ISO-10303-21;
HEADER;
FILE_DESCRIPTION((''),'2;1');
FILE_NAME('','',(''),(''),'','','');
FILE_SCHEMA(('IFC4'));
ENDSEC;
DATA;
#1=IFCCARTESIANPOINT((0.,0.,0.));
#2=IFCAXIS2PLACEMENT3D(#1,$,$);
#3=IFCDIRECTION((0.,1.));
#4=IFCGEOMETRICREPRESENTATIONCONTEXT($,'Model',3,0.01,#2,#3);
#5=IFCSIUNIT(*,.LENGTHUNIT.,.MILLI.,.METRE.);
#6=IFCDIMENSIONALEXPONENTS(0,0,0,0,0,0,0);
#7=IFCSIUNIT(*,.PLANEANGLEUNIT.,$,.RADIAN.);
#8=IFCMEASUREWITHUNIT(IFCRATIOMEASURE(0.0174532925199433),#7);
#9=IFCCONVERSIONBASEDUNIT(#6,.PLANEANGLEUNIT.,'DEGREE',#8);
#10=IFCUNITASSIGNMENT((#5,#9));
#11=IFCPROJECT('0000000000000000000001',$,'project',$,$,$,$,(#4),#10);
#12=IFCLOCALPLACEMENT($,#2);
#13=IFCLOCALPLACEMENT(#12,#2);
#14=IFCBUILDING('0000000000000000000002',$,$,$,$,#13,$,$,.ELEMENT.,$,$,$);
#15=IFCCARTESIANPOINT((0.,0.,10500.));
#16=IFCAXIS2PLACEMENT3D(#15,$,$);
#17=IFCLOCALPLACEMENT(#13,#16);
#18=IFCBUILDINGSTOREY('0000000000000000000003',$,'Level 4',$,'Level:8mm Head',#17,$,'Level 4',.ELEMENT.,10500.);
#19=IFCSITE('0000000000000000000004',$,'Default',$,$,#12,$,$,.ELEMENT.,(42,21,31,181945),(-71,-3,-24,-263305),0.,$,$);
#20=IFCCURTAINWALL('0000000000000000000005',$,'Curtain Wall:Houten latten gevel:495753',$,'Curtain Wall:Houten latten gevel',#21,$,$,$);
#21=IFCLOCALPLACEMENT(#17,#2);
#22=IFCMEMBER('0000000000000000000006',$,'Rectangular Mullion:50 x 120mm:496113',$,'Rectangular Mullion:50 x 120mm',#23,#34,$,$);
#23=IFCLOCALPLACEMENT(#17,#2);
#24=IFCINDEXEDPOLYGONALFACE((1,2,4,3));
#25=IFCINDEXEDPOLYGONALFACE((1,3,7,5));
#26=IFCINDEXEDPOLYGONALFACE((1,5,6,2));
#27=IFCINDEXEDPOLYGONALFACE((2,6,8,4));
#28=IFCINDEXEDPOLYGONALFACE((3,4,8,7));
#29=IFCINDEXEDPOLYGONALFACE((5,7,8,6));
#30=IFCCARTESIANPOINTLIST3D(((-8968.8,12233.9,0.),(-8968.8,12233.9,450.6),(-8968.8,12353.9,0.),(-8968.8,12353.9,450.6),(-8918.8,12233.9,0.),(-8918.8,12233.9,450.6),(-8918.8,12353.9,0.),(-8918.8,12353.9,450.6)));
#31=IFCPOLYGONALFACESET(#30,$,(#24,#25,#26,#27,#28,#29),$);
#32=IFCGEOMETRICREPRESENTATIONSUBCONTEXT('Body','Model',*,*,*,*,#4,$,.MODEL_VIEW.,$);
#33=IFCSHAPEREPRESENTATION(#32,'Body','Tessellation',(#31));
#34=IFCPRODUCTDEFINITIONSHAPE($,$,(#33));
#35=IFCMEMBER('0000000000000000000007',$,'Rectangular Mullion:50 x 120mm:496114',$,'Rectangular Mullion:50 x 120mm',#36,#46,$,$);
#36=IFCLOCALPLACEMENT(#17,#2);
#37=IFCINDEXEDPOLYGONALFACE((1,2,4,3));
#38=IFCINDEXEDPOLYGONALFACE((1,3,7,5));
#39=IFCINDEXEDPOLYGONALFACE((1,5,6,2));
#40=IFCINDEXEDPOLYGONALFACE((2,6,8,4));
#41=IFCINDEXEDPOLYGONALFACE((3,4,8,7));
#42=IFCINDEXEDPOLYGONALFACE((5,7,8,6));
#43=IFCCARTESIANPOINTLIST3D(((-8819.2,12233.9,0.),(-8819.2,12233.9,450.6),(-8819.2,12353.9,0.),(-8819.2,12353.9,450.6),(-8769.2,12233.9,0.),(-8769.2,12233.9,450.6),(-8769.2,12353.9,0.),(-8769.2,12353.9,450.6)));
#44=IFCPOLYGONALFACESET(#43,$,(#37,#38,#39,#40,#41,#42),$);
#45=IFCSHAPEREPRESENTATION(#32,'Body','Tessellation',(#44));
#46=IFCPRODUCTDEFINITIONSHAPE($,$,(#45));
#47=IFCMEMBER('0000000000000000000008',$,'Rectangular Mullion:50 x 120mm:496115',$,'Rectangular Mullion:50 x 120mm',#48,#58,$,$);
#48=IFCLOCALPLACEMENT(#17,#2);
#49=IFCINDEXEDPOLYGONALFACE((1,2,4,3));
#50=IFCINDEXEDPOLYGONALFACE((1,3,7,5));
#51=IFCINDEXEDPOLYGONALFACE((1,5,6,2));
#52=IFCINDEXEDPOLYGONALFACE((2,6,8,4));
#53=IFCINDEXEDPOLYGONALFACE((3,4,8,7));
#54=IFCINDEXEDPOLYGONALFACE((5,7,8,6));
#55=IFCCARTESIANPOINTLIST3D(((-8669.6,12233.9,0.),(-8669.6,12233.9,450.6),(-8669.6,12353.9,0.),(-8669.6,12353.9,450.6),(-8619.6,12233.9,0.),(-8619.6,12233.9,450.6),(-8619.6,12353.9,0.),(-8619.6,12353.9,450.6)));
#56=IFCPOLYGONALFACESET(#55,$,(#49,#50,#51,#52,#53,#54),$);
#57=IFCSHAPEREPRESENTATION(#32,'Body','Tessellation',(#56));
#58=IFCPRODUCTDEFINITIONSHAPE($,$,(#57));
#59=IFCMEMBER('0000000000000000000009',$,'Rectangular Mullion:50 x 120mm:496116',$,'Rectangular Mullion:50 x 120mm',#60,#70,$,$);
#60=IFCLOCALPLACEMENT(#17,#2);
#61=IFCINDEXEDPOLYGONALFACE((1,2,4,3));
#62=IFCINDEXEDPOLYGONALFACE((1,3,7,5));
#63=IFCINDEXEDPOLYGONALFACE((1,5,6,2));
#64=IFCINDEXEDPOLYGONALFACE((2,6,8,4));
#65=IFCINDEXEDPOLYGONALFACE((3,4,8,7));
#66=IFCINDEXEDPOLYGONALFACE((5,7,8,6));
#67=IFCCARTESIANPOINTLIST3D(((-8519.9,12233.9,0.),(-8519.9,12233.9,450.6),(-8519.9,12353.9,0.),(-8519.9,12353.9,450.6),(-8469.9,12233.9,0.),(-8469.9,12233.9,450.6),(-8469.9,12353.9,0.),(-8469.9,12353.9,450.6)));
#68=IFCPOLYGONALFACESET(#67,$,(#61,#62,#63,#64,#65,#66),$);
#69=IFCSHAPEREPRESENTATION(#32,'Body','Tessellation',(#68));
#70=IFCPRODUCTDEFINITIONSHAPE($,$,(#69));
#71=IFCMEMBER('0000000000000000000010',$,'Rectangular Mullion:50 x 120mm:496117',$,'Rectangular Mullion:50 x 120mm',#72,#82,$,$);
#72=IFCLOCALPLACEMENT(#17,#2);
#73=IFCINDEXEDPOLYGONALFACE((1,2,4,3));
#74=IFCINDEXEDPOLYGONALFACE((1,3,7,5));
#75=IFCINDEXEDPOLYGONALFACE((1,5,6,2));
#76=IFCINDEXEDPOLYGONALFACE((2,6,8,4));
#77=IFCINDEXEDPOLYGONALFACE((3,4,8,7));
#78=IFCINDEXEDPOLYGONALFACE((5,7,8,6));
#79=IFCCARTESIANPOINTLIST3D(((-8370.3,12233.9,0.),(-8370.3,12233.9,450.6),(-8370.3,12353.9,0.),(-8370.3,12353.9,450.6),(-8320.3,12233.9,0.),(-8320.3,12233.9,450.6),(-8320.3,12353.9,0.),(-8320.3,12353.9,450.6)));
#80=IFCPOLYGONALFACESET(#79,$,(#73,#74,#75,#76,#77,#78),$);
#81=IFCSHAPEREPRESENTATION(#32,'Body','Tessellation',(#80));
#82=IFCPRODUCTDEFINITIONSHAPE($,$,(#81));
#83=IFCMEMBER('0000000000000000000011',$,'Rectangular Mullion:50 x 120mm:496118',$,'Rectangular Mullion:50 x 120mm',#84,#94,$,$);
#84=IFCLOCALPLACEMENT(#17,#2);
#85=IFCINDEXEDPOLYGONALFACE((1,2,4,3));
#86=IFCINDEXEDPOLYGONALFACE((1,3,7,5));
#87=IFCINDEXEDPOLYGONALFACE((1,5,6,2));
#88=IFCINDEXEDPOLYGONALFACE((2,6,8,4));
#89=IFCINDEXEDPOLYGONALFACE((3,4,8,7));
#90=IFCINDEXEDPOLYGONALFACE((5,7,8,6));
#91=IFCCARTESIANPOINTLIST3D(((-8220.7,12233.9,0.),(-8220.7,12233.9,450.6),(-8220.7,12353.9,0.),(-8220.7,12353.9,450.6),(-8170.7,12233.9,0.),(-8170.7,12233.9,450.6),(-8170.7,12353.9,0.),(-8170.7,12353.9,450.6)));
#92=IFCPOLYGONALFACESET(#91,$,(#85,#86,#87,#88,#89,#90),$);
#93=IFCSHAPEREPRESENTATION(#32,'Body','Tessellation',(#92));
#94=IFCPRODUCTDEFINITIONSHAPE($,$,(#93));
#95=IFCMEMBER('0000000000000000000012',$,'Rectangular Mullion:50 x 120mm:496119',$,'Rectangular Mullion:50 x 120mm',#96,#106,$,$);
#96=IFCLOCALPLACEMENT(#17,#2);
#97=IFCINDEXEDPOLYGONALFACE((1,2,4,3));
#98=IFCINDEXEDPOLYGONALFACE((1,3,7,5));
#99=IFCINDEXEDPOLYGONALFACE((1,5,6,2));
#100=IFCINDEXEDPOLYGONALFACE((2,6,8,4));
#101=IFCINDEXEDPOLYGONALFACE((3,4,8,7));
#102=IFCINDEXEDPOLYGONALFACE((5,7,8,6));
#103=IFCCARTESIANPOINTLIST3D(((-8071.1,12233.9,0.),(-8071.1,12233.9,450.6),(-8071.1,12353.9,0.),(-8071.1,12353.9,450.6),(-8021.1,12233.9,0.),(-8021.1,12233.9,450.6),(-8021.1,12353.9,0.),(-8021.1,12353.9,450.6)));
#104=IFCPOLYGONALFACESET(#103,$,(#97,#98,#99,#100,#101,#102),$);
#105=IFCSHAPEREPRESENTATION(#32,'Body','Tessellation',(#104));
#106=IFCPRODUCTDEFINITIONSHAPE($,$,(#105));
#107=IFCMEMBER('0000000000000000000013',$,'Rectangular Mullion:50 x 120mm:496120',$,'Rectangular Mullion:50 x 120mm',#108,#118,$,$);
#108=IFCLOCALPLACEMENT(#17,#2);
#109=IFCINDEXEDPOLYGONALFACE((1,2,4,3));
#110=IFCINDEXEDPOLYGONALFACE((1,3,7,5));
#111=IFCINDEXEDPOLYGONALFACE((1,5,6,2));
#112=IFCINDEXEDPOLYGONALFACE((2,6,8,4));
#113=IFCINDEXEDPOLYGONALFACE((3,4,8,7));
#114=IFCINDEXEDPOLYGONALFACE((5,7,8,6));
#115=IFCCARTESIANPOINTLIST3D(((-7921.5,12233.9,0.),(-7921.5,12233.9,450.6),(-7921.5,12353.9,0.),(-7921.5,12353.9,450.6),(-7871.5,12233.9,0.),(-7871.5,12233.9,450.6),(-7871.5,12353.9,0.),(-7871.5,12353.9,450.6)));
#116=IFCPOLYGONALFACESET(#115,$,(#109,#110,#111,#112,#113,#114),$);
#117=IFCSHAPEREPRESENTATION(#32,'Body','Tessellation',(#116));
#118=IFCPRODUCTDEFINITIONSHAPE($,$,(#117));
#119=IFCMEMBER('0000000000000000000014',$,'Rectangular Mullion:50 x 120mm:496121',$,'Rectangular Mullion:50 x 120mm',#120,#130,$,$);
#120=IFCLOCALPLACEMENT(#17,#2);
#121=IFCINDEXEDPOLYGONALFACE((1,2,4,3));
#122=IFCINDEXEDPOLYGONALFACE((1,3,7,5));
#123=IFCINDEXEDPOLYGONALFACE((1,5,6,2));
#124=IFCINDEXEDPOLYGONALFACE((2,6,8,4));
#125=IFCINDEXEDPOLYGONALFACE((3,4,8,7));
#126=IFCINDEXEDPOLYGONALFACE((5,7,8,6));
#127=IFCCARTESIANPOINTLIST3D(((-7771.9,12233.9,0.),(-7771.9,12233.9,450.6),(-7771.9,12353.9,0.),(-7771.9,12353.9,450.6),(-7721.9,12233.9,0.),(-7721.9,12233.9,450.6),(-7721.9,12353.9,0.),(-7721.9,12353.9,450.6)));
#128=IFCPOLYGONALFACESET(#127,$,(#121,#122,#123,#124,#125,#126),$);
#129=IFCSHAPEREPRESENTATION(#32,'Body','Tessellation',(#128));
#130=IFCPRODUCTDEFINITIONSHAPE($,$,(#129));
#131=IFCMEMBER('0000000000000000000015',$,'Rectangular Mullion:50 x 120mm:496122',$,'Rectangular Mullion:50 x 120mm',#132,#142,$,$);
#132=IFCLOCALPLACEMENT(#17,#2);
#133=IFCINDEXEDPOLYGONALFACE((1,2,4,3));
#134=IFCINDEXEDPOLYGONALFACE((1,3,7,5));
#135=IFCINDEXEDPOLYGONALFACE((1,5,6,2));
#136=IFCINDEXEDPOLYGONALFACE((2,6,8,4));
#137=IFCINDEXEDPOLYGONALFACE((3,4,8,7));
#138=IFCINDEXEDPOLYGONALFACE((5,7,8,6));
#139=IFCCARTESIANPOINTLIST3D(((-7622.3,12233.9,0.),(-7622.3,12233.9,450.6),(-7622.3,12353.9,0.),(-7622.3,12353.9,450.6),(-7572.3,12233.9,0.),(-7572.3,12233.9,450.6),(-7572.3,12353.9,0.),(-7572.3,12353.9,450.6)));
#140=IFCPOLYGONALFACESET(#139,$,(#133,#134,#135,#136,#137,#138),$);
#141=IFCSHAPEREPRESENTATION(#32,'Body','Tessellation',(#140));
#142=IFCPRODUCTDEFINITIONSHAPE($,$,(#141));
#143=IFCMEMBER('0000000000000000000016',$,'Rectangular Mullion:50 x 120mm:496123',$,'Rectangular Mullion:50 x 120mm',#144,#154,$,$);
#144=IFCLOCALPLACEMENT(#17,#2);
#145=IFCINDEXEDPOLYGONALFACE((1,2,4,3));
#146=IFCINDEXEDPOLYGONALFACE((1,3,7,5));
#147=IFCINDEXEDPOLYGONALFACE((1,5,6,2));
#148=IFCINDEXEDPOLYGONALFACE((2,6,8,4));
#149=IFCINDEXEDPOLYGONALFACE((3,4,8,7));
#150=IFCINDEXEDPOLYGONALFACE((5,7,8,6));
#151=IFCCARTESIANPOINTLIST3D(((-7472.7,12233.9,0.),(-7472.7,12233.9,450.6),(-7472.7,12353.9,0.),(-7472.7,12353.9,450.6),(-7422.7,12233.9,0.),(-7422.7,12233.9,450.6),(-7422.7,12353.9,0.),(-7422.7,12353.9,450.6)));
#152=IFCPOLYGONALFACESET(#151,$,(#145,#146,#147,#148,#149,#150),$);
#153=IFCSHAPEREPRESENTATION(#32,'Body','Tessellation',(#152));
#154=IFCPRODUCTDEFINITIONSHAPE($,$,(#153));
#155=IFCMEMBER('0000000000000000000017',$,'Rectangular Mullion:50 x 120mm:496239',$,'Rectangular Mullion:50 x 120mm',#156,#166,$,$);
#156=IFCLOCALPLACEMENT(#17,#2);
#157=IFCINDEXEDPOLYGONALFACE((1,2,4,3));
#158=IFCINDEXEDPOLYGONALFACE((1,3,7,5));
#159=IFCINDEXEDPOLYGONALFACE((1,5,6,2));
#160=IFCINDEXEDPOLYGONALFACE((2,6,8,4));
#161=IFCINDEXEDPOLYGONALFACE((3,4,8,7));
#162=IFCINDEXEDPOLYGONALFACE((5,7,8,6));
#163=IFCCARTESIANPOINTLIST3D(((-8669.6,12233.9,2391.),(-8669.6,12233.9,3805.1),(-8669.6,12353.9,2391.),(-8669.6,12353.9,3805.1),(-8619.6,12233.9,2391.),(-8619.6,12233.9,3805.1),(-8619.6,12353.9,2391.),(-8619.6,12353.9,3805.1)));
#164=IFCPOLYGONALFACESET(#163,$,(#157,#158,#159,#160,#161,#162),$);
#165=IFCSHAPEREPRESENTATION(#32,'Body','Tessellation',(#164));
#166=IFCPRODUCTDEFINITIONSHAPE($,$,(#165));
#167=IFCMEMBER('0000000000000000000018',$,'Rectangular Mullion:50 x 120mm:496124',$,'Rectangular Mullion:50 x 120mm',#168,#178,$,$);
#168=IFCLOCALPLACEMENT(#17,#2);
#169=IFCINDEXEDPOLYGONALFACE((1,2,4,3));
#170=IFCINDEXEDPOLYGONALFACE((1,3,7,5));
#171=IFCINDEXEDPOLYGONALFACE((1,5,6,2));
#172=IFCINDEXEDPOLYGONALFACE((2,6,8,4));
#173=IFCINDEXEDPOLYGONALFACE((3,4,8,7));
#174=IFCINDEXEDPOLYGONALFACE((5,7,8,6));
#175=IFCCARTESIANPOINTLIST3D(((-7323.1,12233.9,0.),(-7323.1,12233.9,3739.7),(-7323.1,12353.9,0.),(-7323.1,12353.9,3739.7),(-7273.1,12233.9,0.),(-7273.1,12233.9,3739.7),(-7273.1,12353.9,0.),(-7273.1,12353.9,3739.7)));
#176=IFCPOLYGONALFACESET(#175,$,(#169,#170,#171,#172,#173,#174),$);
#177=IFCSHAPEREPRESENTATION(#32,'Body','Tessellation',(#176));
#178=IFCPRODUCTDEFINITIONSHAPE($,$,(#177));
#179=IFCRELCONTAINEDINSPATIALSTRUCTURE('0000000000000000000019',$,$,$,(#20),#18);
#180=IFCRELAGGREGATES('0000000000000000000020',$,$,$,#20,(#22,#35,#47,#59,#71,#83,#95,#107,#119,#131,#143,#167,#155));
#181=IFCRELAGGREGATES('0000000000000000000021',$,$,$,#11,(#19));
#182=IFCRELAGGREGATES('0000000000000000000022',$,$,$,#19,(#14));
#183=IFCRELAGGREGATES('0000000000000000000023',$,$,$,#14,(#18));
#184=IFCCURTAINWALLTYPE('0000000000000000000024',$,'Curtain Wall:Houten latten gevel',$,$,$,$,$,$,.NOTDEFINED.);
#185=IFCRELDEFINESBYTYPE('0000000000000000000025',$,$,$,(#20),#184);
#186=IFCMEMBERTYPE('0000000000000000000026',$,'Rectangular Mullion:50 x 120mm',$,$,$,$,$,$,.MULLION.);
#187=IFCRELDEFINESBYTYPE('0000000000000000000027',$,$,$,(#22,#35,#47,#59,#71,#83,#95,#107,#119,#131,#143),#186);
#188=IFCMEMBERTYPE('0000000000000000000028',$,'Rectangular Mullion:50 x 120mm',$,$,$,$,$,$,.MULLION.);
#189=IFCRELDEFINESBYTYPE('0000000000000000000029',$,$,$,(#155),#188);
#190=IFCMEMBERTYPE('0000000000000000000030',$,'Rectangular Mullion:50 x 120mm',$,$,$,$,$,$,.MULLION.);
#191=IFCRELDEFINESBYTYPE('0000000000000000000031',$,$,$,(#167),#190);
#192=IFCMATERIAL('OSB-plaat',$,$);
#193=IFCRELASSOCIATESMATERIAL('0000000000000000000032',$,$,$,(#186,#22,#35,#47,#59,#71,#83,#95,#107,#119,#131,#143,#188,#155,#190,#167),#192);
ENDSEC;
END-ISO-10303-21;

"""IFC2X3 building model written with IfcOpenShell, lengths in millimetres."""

from ifc_helpers import new_model, entity, si_unit, converted_unit, direction, frame, origin, origin_2d_with_axis, place, context, subcontext, project, spatial, rectangle, extrude, source, transform, mapped, material, type_object, type_shapes, element, aggregate, save


model = new_model("IFC2X3")

# Units and contexts
model_context = context("Model", 3, precision=0.01, world=origin(), true_north=direction((0.0, 1.0)))
body_context = subcontext(model_context, "Body", "Model", "MODEL_VIEW")
ifc_project = project(units=[si_unit("LENGTHUNIT", "METRE", prefix="MILLI"), converted_unit("PLANEANGLEUNIT", "DEGREE", entity("IfcRatioMeasure", 0.0174532925199433), si_unit("PLANEANGLEUNIT", "RADIAN"), dimensions=[0, 0, 0, 0, 0, 0, 0])], contexts=[model_context])

# Site, building, storey
site_placement = place(None, frame((0.0, 0.0, 0.0)))
site = spatial("IfcSite", under=ifc_project, at=site_placement, Name="Default", CompositionType="ELEMENT", RefLatitude=(42, 21, 31, 181945), RefLongitude=(-71, -3, -24, -263305), RefElevation=0.0)
building_placement = place(site_placement, origin())
building = spatial("IfcBuilding", under=site, at=building_placement, CompositionType="ELEMENT")
storey_placement = place(building_placement, frame((0.0, 0.0, 10500.0)))
storey = spatial("IfcBuildingStorey", under=building, at=storey_placement, Name="Level 4", ObjectType="Level:8mm Head", LongName="Level 4", CompositionType="ELEMENT", Elevation=10500.0)

# Curtain wall, members
curtain_wall_type = type_object("IfcCurtainWallType", Name="Curtain Wall:Houten latten gevel", PredefinedType="NOTDEFINED")
curtain_wall_placement = place(storey_placement, frame((0.0, 0.0, -10500.0)))
curtain_wall = element("IfcCurtainWall", 1, at=curtain_wall_placement, inside=storey, type_object=curtain_wall_type, Name="Curtain Wall:Houten latten gevel:495753", ObjectType="Curtain Wall:Houten latten gevel")
ifc_material = material(Name="OSB-plaat")
member_type_1 = type_object("IfcMemberType", Name="Rectangular Mullion:50 x 120mm", PredefinedType="MULLION", material=ifc_material)
shared_shape_1 = source(origin(), body_context, "Body", "SweptSolid", [
    extrude(rectangle(XDim=120.0, YDim=50.0, at=origin_2d_with_axis()), frame((0.0, 0.0, -450.6), z_axis=(0.0, 0.0, 1.0), x_axis=(0.0, -1.0, 0.0)), (0.0, 0.0, 1.0), 450.6),
])
type_shapes(member_type_1, [shared_shape_1])
placement = place(building_placement, frame((0.0, 0.0, 7500.0)))
member_1_placement = place(placement, frame((-8943.8, 12293.9, 3000.0), z_axis=(0.0, 0.0, -1.0), x_axis=(1.0, 0.0, 0.0)))
member_1 = element("IfcMember", 2, at=member_1_placement, type_object=member_type_1, material=ifc_material, Name="Rectangular Mullion:50 x 120mm:496113", ObjectType="Rectangular Mullion:50 x 120mm", context=body_context, shape_type="MappedRepresentation", body=[
    mapped(shared_shape_1, transform((0.0, 0.0, 0.0), scale=1.0)),
])
member_2_placement = place(placement, frame((-8794.2, 12293.9, 3000.0), z_axis=(0.0, 0.0, -1.0), x_axis=(1.0, 0.0, 0.0)))
member_2 = element("IfcMember", 3, at=member_2_placement, type_object=member_type_1, material=ifc_material, Name="Rectangular Mullion:50 x 120mm:496114", ObjectType="Rectangular Mullion:50 x 120mm", context=body_context, shape_type="MappedRepresentation", body=[
    mapped(shared_shape_1, transform((0.0, 0.0, 0.0), scale=1.0)),
])
member_3_placement = place(placement, frame((-8644.6, 12293.9, 3000.0), z_axis=(0.0, 0.0, -1.0), x_axis=(1.0, 0.0, 0.0)))
member_3 = element("IfcMember", 4, at=member_3_placement, type_object=member_type_1, material=ifc_material, Name="Rectangular Mullion:50 x 120mm:496115", ObjectType="Rectangular Mullion:50 x 120mm", context=body_context, shape_type="MappedRepresentation", body=[
    mapped(shared_shape_1, transform((0.0, 0.0, 0.0), scale=1.0)),
])
member_4_placement = place(placement, frame((-8494.9, 12293.9, 3000.0), z_axis=(0.0, 0.0, -1.0), x_axis=(1.0, 0.0, 0.0)))
member_4 = element("IfcMember", 5, at=member_4_placement, type_object=member_type_1, material=ifc_material, Name="Rectangular Mullion:50 x 120mm:496116", ObjectType="Rectangular Mullion:50 x 120mm", context=body_context, shape_type="MappedRepresentation", body=[
    mapped(shared_shape_1, transform((0.0, 0.0, 0.0), scale=1.0)),
])
member_5_placement = place(placement, frame((-8345.3, 12293.9, 3000.0), z_axis=(0.0, 0.0, -1.0), x_axis=(1.0, 0.0, 0.0)))
member_5 = element("IfcMember", 6, at=member_5_placement, type_object=member_type_1, material=ifc_material, Name="Rectangular Mullion:50 x 120mm:496117", ObjectType="Rectangular Mullion:50 x 120mm", context=body_context, shape_type="MappedRepresentation", body=[
    mapped(shared_shape_1, transform((0.0, 0.0, 0.0), scale=1.0)),
])
member_6_placement = place(placement, frame((-8195.7, 12293.9, 3000.0), z_axis=(0.0, 0.0, -1.0), x_axis=(1.0, 0.0, 0.0)))
member_6 = element("IfcMember", 7, at=member_6_placement, type_object=member_type_1, material=ifc_material, Name="Rectangular Mullion:50 x 120mm:496118", ObjectType="Rectangular Mullion:50 x 120mm", context=body_context, shape_type="MappedRepresentation", body=[
    mapped(shared_shape_1, transform((0.0, 0.0, 0.0), scale=1.0)),
])
member_7_placement = place(placement, frame((-8046.1, 12293.9, 3000.0), z_axis=(0.0, 0.0, -1.0), x_axis=(1.0, 0.0, 0.0)))
member_7 = element("IfcMember", 8, at=member_7_placement, type_object=member_type_1, material=ifc_material, Name="Rectangular Mullion:50 x 120mm:496119", ObjectType="Rectangular Mullion:50 x 120mm", context=body_context, shape_type="MappedRepresentation", body=[
    mapped(shared_shape_1, transform((0.0, 0.0, 0.0), scale=1.0)),
])
member_8_placement = place(placement, frame((-7896.5, 12293.9, 3000.0), z_axis=(0.0, 0.0, -1.0), x_axis=(1.0, 0.0, 0.0)))
member_8 = element("IfcMember", 9, at=member_8_placement, type_object=member_type_1, material=ifc_material, Name="Rectangular Mullion:50 x 120mm:496120", ObjectType="Rectangular Mullion:50 x 120mm", context=body_context, shape_type="MappedRepresentation", body=[
    mapped(shared_shape_1, transform((0.0, 0.0, 0.0), scale=1.0)),
])
member_9_placement = place(placement, frame((-7746.9, 12293.9, 3000.0), z_axis=(0.0, 0.0, -1.0), x_axis=(1.0, 0.0, 0.0)))
member_9 = element("IfcMember", 10, at=member_9_placement, type_object=member_type_1, material=ifc_material, Name="Rectangular Mullion:50 x 120mm:496121", ObjectType="Rectangular Mullion:50 x 120mm", context=body_context, shape_type="MappedRepresentation", body=[
    mapped(shared_shape_1, transform((0.0, 0.0, 0.0), scale=1.0)),
])
member_10_placement = place(placement, frame((-7597.3, 12293.9, 3000.0), z_axis=(0.0, 0.0, -1.0), x_axis=(1.0, 0.0, 0.0)))
member_10 = element("IfcMember", 11, at=member_10_placement, type_object=member_type_1, material=ifc_material, Name="Rectangular Mullion:50 x 120mm:496122", ObjectType="Rectangular Mullion:50 x 120mm", context=body_context, shape_type="MappedRepresentation", body=[
    mapped(shared_shape_1, transform((0.0, 0.0, 0.0), scale=1.0)),
])
member_11_placement = place(placement, frame((-7447.7, 12293.9, 3000.0), z_axis=(0.0, 0.0, -1.0), x_axis=(1.0, 0.0, 0.0)))
member_11 = element("IfcMember", 12, at=member_11_placement, type_object=member_type_1, material=ifc_material, Name="Rectangular Mullion:50 x 120mm:496123", ObjectType="Rectangular Mullion:50 x 120mm", context=body_context, shape_type="MappedRepresentation", body=[
    mapped(shared_shape_1, transform((0.0, 0.0, 0.0), scale=1.0)),
])
member_type_2 = type_object("IfcMemberType", Name="Rectangular Mullion:50 x 120mm", PredefinedType="MULLION", material=ifc_material)
shared_shape_2 = source(origin(), body_context, "Body", "SweptSolid", [
    extrude(rectangle(XDim=120.0, YDim=50.0, at=origin_2d_with_axis()), frame((0.0, 0.0, -1414.1), z_axis=(0.0, 0.0, 1.0), x_axis=(0.0, -1.0, 0.0)), (0.0, 0.0, 1.0), 1414.1),
])
type_shapes(member_type_2, [shared_shape_2])
member_12_placement = place(placement, frame((-8644.6, 12293.9, 5391.0), z_axis=(0.0, 0.0, -1.0), x_axis=(1.0, 0.0, 0.0)))
member_12 = element("IfcMember", 13, at=member_12_placement, type_object=member_type_2, material=ifc_material, Name="Rectangular Mullion:50 x 120mm:496239", ObjectType="Rectangular Mullion:50 x 120mm", context=body_context, shape_type="MappedRepresentation", body=[
    mapped(shared_shape_2, transform((0.0, 0.0, 0.0), scale=1.0)),
])
member_type_3 = type_object("IfcMemberType", Name="Rectangular Mullion:50 x 120mm", PredefinedType="MULLION", material=ifc_material)
shared_shape_3 = source(origin(), body_context, "Body", "SweptSolid", [
    extrude(rectangle(XDim=120.0, YDim=50.0, at=origin_2d_with_axis()), frame((0.0, 0.0, -3739.7), z_axis=(0.0, 0.0, 1.0), x_axis=(0.0, -1.0, 0.0)), (0.0, 0.0, 1.0), 3739.7),
])
type_shapes(member_type_3, [shared_shape_3])
member_13_placement = place(placement, frame((-7298.1, 12293.9, 3000.0), z_axis=(0.0, 0.0, -1.0), x_axis=(1.0, 0.0, 0.0)))
member_13 = element("IfcMember", 14, at=member_13_placement, type_object=member_type_3, material=ifc_material, Name="Rectangular Mullion:50 x 120mm:496124", ObjectType="Rectangular Mullion:50 x 120mm", context=body_context, shape_type="MappedRepresentation", body=[
    mapped(shared_shape_3, transform((0.0, 0.0, 0.0), scale=1.0)),
])
aggregate(curtain_wall, [member_1, member_2, member_3, member_4, member_5, member_6, member_7, member_8, member_9, member_10, member_11, member_13, member_12])

save(model, "model.ifc")
